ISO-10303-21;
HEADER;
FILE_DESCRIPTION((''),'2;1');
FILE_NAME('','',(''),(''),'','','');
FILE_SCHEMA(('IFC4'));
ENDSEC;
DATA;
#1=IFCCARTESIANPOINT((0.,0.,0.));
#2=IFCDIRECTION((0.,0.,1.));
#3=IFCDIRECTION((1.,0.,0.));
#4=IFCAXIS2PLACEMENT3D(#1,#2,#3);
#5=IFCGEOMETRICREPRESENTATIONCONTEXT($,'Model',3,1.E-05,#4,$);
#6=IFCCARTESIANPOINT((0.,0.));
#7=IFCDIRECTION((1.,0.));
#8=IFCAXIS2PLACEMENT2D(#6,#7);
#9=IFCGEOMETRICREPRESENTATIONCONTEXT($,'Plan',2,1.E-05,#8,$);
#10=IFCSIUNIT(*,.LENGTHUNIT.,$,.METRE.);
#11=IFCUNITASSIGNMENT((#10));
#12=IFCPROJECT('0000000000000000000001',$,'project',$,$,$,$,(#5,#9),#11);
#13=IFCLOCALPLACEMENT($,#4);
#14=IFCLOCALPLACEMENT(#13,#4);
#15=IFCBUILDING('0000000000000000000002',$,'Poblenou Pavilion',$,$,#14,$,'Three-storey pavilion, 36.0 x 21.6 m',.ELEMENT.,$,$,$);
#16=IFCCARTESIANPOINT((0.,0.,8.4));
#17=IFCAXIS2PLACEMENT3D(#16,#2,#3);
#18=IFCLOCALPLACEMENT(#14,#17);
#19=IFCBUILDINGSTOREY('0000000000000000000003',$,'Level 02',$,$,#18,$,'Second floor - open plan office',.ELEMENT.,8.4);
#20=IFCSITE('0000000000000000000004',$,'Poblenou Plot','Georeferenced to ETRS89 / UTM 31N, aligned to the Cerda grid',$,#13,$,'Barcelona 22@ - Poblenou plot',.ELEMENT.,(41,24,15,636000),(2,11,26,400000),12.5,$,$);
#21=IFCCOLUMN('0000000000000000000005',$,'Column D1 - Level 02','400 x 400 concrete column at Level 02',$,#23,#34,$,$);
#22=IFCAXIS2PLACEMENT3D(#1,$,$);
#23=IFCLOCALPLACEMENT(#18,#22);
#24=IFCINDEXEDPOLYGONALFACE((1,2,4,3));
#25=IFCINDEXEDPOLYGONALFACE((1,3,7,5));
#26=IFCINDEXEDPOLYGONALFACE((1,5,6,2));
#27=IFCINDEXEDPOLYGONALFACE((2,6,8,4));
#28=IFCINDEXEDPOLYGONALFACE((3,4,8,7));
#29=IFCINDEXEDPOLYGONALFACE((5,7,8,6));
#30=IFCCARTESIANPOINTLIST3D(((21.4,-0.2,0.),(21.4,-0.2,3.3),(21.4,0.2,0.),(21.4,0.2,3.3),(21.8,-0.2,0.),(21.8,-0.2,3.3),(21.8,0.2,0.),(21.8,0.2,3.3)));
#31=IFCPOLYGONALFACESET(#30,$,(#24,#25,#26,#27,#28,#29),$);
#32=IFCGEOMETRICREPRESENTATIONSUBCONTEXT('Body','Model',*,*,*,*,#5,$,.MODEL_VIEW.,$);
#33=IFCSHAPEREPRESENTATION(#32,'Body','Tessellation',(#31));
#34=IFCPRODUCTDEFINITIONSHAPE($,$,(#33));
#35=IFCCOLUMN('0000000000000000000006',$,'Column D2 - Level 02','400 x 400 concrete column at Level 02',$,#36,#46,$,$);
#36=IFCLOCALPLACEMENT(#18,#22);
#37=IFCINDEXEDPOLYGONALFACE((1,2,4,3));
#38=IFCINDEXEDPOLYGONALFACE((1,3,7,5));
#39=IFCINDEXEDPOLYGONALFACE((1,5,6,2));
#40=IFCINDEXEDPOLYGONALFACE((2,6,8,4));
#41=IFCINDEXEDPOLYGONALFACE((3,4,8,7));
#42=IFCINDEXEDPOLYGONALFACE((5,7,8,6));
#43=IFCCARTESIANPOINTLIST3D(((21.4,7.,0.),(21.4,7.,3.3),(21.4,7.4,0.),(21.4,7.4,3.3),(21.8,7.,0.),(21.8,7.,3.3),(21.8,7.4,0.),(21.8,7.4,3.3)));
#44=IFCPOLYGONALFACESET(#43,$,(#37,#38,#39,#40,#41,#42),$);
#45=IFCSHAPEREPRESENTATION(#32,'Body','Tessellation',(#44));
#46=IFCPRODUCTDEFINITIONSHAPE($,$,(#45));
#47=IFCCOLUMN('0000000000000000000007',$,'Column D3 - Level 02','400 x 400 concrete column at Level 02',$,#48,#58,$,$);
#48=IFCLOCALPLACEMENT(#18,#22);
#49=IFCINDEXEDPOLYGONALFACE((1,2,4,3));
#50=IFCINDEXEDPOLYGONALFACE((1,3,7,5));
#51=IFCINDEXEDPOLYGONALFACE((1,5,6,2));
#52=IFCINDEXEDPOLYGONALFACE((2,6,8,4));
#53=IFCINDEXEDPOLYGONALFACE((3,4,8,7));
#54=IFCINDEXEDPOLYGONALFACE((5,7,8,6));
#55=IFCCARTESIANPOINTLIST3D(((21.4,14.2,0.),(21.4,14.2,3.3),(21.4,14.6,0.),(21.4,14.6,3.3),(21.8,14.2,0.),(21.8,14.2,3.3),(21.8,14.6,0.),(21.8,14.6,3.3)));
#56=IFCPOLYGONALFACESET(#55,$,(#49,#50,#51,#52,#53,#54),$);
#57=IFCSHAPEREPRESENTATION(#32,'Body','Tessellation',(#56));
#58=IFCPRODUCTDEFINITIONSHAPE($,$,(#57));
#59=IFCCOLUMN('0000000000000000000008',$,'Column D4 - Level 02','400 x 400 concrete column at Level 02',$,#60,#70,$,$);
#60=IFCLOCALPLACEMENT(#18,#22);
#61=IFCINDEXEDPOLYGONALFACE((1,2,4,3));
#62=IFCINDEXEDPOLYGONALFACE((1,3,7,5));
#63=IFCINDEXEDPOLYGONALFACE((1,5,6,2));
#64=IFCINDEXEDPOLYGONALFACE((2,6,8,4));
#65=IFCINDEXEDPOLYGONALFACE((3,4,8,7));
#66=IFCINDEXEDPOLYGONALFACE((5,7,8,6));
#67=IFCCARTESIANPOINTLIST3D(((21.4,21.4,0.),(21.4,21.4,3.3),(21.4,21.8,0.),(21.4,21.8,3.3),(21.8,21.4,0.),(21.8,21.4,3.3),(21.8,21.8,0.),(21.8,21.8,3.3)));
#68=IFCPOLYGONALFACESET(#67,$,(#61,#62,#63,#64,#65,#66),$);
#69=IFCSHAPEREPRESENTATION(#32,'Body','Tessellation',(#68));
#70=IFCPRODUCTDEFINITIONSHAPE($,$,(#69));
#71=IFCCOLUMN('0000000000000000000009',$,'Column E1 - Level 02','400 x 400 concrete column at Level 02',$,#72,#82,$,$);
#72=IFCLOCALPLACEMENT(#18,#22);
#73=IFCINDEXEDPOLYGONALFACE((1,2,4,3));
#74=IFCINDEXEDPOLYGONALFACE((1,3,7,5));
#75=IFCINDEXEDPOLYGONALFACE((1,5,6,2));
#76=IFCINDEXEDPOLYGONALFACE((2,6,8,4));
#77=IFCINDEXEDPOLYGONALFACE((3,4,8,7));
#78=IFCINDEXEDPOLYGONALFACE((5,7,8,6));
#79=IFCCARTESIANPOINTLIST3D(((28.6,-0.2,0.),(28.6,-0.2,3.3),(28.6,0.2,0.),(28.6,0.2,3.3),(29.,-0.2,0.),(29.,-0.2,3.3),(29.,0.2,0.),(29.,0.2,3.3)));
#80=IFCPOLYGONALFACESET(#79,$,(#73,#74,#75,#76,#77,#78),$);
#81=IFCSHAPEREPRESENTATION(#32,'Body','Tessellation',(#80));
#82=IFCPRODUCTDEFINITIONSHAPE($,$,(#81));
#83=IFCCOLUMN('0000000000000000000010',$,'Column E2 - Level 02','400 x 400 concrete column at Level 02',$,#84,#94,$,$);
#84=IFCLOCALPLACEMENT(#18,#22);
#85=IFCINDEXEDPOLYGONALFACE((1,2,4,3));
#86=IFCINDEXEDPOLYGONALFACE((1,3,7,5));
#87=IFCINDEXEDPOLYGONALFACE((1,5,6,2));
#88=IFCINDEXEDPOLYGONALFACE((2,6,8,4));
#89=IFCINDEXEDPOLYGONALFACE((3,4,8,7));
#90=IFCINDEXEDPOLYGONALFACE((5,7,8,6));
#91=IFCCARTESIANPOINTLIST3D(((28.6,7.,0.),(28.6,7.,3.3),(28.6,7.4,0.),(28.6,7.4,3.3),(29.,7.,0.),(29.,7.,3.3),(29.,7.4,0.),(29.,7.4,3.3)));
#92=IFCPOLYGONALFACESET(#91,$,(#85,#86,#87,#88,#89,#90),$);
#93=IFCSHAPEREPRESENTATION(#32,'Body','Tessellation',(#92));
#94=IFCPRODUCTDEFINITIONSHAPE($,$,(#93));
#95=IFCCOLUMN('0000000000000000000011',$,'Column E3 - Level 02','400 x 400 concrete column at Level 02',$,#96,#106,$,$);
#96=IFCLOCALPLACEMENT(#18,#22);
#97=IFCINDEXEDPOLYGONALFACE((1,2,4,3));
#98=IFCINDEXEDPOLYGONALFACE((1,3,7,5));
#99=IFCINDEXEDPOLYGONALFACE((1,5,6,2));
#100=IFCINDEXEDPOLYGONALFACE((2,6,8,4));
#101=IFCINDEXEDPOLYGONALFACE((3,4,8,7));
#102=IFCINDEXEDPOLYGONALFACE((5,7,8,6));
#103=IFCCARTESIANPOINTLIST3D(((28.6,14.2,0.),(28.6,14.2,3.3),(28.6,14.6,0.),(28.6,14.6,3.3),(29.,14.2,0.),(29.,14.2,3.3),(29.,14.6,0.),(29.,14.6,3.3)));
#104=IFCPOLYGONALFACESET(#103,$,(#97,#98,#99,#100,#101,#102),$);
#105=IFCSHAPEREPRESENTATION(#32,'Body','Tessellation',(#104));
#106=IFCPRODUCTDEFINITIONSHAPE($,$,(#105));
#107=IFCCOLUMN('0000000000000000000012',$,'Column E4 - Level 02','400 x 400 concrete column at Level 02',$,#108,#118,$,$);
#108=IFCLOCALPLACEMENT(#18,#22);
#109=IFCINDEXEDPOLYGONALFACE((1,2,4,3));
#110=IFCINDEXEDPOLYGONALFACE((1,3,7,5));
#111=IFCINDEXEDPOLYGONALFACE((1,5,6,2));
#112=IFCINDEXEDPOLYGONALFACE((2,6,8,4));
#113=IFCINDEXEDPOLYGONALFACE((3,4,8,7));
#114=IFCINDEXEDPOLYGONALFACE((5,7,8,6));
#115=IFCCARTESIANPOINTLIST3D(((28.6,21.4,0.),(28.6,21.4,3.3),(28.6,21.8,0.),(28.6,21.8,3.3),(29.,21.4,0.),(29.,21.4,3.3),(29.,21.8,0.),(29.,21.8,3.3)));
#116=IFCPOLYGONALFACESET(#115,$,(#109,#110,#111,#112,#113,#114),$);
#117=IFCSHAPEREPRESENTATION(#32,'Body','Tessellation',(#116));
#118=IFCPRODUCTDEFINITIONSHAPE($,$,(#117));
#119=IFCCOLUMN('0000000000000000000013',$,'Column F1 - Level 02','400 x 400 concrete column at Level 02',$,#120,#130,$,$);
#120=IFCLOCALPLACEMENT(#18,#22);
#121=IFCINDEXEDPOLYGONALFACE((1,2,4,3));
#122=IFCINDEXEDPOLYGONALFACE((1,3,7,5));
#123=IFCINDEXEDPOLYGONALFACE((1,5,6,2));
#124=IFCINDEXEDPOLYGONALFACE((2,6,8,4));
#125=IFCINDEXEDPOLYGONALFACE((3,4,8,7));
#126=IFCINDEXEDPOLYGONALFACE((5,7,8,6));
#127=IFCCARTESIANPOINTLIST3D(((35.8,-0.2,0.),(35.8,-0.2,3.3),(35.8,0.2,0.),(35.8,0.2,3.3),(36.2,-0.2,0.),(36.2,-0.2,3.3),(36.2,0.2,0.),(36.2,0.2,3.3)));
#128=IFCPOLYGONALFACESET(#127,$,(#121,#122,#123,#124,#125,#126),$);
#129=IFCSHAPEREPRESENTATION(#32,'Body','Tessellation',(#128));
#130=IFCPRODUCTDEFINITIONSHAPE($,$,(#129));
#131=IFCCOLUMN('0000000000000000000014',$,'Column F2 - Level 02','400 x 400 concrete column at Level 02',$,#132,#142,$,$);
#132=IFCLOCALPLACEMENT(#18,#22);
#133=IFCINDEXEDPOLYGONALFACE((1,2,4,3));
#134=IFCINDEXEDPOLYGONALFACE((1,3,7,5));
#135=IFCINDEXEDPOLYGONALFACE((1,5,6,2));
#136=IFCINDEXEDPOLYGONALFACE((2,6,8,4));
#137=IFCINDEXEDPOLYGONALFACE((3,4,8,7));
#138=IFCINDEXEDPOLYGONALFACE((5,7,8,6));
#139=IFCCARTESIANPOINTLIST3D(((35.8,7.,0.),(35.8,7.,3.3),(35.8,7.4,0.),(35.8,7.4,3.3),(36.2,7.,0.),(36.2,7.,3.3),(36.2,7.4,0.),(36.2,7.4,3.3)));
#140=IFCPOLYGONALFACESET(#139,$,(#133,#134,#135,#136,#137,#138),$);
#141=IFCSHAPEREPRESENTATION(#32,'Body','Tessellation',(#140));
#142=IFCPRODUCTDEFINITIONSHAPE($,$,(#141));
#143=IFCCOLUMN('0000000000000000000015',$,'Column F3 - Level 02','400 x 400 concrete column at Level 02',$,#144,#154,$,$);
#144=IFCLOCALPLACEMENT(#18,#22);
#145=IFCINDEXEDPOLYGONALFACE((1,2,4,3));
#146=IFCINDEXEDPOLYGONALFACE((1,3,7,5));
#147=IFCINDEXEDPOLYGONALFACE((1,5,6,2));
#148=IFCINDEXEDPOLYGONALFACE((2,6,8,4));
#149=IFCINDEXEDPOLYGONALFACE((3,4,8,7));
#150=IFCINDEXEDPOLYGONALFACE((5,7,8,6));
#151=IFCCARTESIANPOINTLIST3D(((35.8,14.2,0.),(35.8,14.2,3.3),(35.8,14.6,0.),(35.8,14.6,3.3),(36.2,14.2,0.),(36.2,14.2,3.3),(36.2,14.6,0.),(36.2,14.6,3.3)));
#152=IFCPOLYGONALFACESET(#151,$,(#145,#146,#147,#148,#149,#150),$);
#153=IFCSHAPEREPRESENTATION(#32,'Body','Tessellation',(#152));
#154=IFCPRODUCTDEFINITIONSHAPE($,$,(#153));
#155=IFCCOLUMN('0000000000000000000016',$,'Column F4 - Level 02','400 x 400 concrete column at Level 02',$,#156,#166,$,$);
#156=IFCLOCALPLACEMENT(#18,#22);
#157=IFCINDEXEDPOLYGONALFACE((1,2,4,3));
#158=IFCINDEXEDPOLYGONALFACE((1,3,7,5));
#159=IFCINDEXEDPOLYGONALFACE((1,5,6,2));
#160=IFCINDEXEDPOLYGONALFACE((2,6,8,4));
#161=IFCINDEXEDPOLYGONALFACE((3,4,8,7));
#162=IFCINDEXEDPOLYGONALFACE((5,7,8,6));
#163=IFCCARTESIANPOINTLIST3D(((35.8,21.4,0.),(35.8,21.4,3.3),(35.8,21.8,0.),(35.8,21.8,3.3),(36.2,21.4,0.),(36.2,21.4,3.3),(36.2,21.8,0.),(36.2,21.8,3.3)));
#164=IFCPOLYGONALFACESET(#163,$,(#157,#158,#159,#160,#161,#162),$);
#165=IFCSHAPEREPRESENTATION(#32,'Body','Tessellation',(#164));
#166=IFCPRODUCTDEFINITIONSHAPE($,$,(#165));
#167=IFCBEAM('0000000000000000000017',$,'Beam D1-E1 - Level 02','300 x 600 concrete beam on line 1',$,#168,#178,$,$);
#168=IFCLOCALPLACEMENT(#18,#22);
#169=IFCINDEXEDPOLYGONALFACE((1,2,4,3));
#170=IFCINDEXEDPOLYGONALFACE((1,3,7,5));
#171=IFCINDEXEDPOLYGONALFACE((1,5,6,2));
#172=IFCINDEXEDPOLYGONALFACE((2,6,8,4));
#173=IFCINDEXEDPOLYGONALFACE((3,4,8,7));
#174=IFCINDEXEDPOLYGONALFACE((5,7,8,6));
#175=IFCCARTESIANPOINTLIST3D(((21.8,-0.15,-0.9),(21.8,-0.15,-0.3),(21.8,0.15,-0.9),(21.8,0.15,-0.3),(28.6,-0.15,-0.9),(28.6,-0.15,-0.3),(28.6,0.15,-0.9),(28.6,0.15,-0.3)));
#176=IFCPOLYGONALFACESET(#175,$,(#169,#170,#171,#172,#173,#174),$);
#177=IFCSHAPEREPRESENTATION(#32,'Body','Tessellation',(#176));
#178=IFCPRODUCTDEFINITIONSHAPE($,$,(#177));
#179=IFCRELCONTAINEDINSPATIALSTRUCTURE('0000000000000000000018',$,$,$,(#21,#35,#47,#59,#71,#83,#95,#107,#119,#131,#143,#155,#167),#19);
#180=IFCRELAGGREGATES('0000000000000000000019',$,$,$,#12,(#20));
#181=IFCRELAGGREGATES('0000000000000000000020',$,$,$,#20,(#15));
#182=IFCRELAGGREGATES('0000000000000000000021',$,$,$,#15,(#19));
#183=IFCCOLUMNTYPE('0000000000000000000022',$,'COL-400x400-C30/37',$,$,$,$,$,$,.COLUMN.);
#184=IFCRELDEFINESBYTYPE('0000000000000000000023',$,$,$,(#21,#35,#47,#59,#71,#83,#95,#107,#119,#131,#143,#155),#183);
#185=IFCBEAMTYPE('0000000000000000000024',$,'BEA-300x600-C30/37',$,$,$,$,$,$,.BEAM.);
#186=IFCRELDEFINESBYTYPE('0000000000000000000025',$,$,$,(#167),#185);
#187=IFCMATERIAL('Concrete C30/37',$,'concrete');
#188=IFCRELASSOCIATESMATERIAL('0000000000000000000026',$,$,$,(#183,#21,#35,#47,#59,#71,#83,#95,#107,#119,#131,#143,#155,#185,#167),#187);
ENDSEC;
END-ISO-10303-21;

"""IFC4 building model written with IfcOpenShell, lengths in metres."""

from ifc_helpers import new_model, si_unit, frame, origin_with_axes, origin_2d_with_axis, place, context, subcontext, project, spatial, line, indexed_curve, rectangle, outline, extrude, material, material_profile, profile_set, profile_usage, type_object, element, save


model = new_model("IFC4")

# Units and contexts
model_context = context("Model", 3, precision=1e-05, world=origin_with_axes())
plan_context = context("Plan", 2, precision=1e-05, world=origin_2d_with_axis())
body_context = subcontext(model_context, "Body", "Model", "MODEL_VIEW")
ifc_project = project(units=[si_unit("LENGTHUNIT", "METRE")], contexts=[model_context, plan_context])

# Site, building, storey
site_placement = place(None, origin_with_axes())
site = spatial("IfcSite", under=ifc_project, at=site_placement, Name="Poblenou Plot", Description="Georeferenced to ETRS89 / UTM 31N, aligned to the Cerda grid", LongName="Barcelona 22@ - Poblenou plot", CompositionType="ELEMENT", RefLatitude=(41, 24, 15, 636000), RefLongitude=(2, 11, 26, 400000), RefElevation=12.5)
building_placement = place(site_placement, origin_with_axes())
building = spatial("IfcBuilding", under=site, at=building_placement, Name="Poblenou Pavilion", LongName="Three-storey pavilion, 36.0 x 21.6 m", CompositionType="ELEMENT")
storey_placement = place(building_placement, frame((0.0, 0.0, 8.4), z_axis=(0.0, 0.0, 1.0), x_axis=(1.0, 0.0, 0.0)))
storey = spatial("IfcBuildingStorey", under=building, at=storey_placement, Name="Level 02", LongName="Second floor - open plan office", CompositionType="ELEMENT", Elevation=8.4)

# Columns
ifc_material = material(Name="Concrete C30/37", Category="concrete")
ifc_material_profile_1 = material_profile(ifc_material, rectangle(XDim=0.4, YDim=0.4))
ifc_profile_set_1 = profile_set([ifc_material_profile_1], Name="COL-400x400-C30/37")
ifc_profile_usage_1 = profile_usage(ifc_profile_set_1)
column_type = type_object("IfcColumnType", Name="COL-400x400-C30/37", PredefinedType="COLUMN", material=ifc_profile_set_1)
column_1_placement = place(storey_placement, frame((21.4, -0.2, 0.0), z_axis=(0.0, 0.0, 1.0), x_axis=(1.0, 0.0, 0.0)))
element("IfcColumn", 1, at=column_1_placement, inside=storey, type_object=column_type, material=ifc_profile_usage_1, Name="Column D1 - Level 02", Description="400 x 400 concrete column at Level 02", context=body_context, shape_type="SweptSolid", body=[
    extrude(outline(indexed_curve([(0.0, 0.0), (0.4, 0.0), (0.4, 0.4), (0.0, 0.4)], segments=[line(1, 2, 3, 4, 1)])), origin_with_axes(), (0.0, 0.0, 1.0), 3.3),
])
ifc_profile_usage_2 = profile_usage(ifc_profile_set_1)
column_2_placement = place(storey_placement, frame((21.4, 7.0, 0.0), z_axis=(0.0, 0.0, 1.0), x_axis=(1.0, 0.0, 0.0)))
element("IfcColumn", 2, at=column_2_placement, inside=storey, type_object=column_type, material=ifc_profile_usage_2, Name="Column D2 - Level 02", Description="400 x 400 concrete column at Level 02", context=body_context, shape_type="SweptSolid", body=[
    extrude(outline(indexed_curve([(0.0, 0.0), (0.4, 0.0), (0.4, 0.4), (0.0, 0.4)], segments=[line(1, 2, 3, 4, 1)])), origin_with_axes(), (0.0, 0.0, 1.0), 3.3),
])
ifc_profile_usage_3 = profile_usage(ifc_profile_set_1)
column_3_placement = place(storey_placement, frame((21.4, 14.2, 0.0), z_axis=(0.0, 0.0, 1.0), x_axis=(1.0, 0.0, 0.0)))
element("IfcColumn", 3, at=column_3_placement, inside=storey, type_object=column_type, material=ifc_profile_usage_3, Name="Column D3 - Level 02", Description="400 x 400 concrete column at Level 02", context=body_context, shape_type="SweptSolid", body=[
    extrude(outline(indexed_curve([(0.0, 0.0), (0.4, 0.0), (0.4, 0.4), (0.0, 0.4)], segments=[line(1, 2, 3, 4, 1)])), origin_with_axes(), (0.0, 0.0, 1.0), 3.3),
])
ifc_profile_usage_4 = profile_usage(ifc_profile_set_1)
column_4_placement = place(storey_placement, frame((21.4, 21.4, 0.0), z_axis=(0.0, 0.0, 1.0), x_axis=(1.0, 0.0, 0.0)))
element("IfcColumn", 4, at=column_4_placement, inside=storey, type_object=column_type, material=ifc_profile_usage_4, Name="Column D4 - Level 02", Description="400 x 400 concrete column at Level 02", context=body_context, shape_type="SweptSolid", body=[
    extrude(outline(indexed_curve([(0.0, 0.0), (0.4, 0.0), (0.4, 0.4), (0.0, 0.4)], segments=[line(1, 2, 3, 4, 1)])), origin_with_axes(), (0.0, 0.0, 1.0), 3.3),
])
ifc_profile_usage_5 = profile_usage(ifc_profile_set_1)
column_5_placement = place(storey_placement, frame((28.6, -0.2, 0.0), z_axis=(0.0, 0.0, 1.0), x_axis=(1.0, 0.0, 0.0)))
element("IfcColumn", 5, at=column_5_placement, inside=storey, type_object=column_type, material=ifc_profile_usage_5, Name="Column E1 - Level 02", Description="400 x 400 concrete column at Level 02", context=body_context, shape_type="SweptSolid", body=[
    extrude(outline(indexed_curve([(0.0, 0.0), (0.4, 0.0), (0.4, 0.4), (0.0, 0.4)], segments=[line(1, 2, 3, 4, 1)])), origin_with_axes(), (0.0, 0.0, 1.0), 3.3),
])
ifc_profile_usage_6 = profile_usage(ifc_profile_set_1)
column_6_placement = place(storey_placement, frame((28.6, 7.0, 0.0), z_axis=(0.0, 0.0, 1.0), x_axis=(1.0, 0.0, 0.0)))
element("IfcColumn", 6, at=column_6_placement, inside=storey, type_object=column_type, material=ifc_profile_usage_6, Name="Column E2 - Level 02", Description="400 x 400 concrete column at Level 02", context=body_context, shape_type="SweptSolid", body=[
    extrude(outline(indexed_curve([(0.0, 0.0), (0.4, 0.0), (0.4, 0.4), (0.0, 0.4)], segments=[line(1, 2, 3, 4, 1)])), origin_with_axes(), (0.0, 0.0, 1.0), 3.3),
])
ifc_profile_usage_7 = profile_usage(ifc_profile_set_1)
column_7_placement = place(storey_placement, frame((28.6, 14.2, 0.0), z_axis=(0.0, 0.0, 1.0), x_axis=(1.0, 0.0, 0.0)))
element("IfcColumn", 7, at=column_7_placement, inside=storey, type_object=column_type, material=ifc_profile_usage_7, Name="Column E3 - Level 02", Description="400 x 400 concrete column at Level 02", context=body_context, shape_type="SweptSolid", body=[
    extrude(outline(indexed_curve([(0.0, 0.0), (0.4, 0.0), (0.4, 0.4), (0.0, 0.4)], segments=[line(1, 2, 3, 4, 1)])), origin_with_axes(), (0.0, 0.0, 1.0), 3.3),
])
ifc_profile_usage_8 = profile_usage(ifc_profile_set_1)
column_8_placement = place(storey_placement, frame((28.6, 21.4, 0.0), z_axis=(0.0, 0.0, 1.0), x_axis=(1.0, 0.0, 0.0)))
element("IfcColumn", 8, at=column_8_placement, inside=storey, type_object=column_type, material=ifc_profile_usage_8, Name="Column E4 - Level 02", Description="400 x 400 concrete column at Level 02", context=body_context, shape_type="SweptSolid", body=[
    extrude(outline(indexed_curve([(0.0, 0.0), (0.4, 0.0), (0.4, 0.4), (0.0, 0.4)], segments=[line(1, 2, 3, 4, 1)])), origin_with_axes(), (0.0, 0.0, 1.0), 3.3),
])
ifc_profile_usage_9 = profile_usage(ifc_profile_set_1)
column_9_placement = place(storey_placement, frame((35.8, -0.2, 0.0), z_axis=(0.0, 0.0, 1.0), x_axis=(1.0, 0.0, 0.0)))
element("IfcColumn", 9, at=column_9_placement, inside=storey, type_object=column_type, material=ifc_profile_usage_9, Name="Column F1 - Level 02", Description="400 x 400 concrete column at Level 02", context=body_context, shape_type="SweptSolid", body=[
    extrude(outline(indexed_curve([(0.0, 0.0), (0.4, 0.0), (0.4, 0.4), (0.0, 0.4)], segments=[line(1, 2, 3, 4, 1)])), origin_with_axes(), (0.0, 0.0, 1.0), 3.3),
])
ifc_profile_usage_10 = profile_usage(ifc_profile_set_1)
column_10_placement = place(storey_placement, frame((35.8, 7.0, 0.0), z_axis=(0.0, 0.0, 1.0), x_axis=(1.0, 0.0, 0.0)))
element("IfcColumn", 10, at=column_10_placement, inside=storey, type_object=column_type, material=ifc_profile_usage_10, Name="Column F2 - Level 02", Description="400 x 400 concrete column at Level 02", context=body_context, shape_type="SweptSolid", body=[
    extrude(outline(indexed_curve([(0.0, 0.0), (0.4, 0.0), (0.4, 0.4), (0.0, 0.4)], segments=[line(1, 2, 3, 4, 1)])), origin_with_axes(), (0.0, 0.0, 1.0), 3.3),
])
ifc_profile_usage_11 = profile_usage(ifc_profile_set_1)
column_11_placement = place(storey_placement, frame((35.8, 14.2, 0.0), z_axis=(0.0, 0.0, 1.0), x_axis=(1.0, 0.0, 0.0)))
element("IfcColumn", 11, at=column_11_placement, inside=storey, type_object=column_type, material=ifc_profile_usage_11, Name="Column F3 - Level 02", Description="400 x 400 concrete column at Level 02", context=body_context, shape_type="SweptSolid", body=[
    extrude(outline(indexed_curve([(0.0, 0.0), (0.4, 0.0), (0.4, 0.4), (0.0, 0.4)], segments=[line(1, 2, 3, 4, 1)])), origin_with_axes(), (0.0, 0.0, 1.0), 3.3),
])
ifc_profile_usage_12 = profile_usage(ifc_profile_set_1)
column_12_placement = place(storey_placement, frame((35.8, 21.4, 0.0), z_axis=(0.0, 0.0, 1.0), x_axis=(1.0, 0.0, 0.0)))
element("IfcColumn", 12, at=column_12_placement, inside=storey, type_object=column_type, material=ifc_profile_usage_12, Name="Column F4 - Level 02", Description="400 x 400 concrete column at Level 02", context=body_context, shape_type="SweptSolid", body=[
    extrude(outline(indexed_curve([(0.0, 0.0), (0.4, 0.0), (0.4, 0.4), (0.0, 0.4)], segments=[line(1, 2, 3, 4, 1)])), origin_with_axes(), (0.0, 0.0, 1.0), 3.3),
])

# Beam
ifc_material_profile_2 = material_profile(ifc_material, rectangle(XDim=0.3, YDim=0.6))
ifc_profile_set_2 = profile_set([ifc_material_profile_2], Name="BEA-300x600-C30/37")
ifc_profile_usage_13 = profile_usage(ifc_profile_set_2)
beam_type = type_object("IfcBeamType", Name="BEA-300x600-C30/37", PredefinedType="BEAM", material=ifc_profile_set_2)
beam_1_placement = place(storey_placement, frame((21.8, -0.15, -0.9), z_axis=(1.0, 0.0, 0.0), x_axis=(0.0, 1.0, 0.0)))
element("IfcBeam", 13, at=beam_1_placement, inside=storey, type_object=beam_type, material=ifc_profile_usage_13, Name="Beam D1-E1 - Level 02", Description="300 x 600 concrete beam on line 1", context=body_context, shape_type="SweptSolid", body=[
    extrude(outline(indexed_curve([(0.0, 0.0), (0.3, 0.0), (0.3, 0.6), (0.0, 0.6)], segments=[line(1, 2, 3, 4, 1)])), origin_with_axes(), (0.0, 0.0, 1.0), 6.8),
])

save(model, "model.ifc")
